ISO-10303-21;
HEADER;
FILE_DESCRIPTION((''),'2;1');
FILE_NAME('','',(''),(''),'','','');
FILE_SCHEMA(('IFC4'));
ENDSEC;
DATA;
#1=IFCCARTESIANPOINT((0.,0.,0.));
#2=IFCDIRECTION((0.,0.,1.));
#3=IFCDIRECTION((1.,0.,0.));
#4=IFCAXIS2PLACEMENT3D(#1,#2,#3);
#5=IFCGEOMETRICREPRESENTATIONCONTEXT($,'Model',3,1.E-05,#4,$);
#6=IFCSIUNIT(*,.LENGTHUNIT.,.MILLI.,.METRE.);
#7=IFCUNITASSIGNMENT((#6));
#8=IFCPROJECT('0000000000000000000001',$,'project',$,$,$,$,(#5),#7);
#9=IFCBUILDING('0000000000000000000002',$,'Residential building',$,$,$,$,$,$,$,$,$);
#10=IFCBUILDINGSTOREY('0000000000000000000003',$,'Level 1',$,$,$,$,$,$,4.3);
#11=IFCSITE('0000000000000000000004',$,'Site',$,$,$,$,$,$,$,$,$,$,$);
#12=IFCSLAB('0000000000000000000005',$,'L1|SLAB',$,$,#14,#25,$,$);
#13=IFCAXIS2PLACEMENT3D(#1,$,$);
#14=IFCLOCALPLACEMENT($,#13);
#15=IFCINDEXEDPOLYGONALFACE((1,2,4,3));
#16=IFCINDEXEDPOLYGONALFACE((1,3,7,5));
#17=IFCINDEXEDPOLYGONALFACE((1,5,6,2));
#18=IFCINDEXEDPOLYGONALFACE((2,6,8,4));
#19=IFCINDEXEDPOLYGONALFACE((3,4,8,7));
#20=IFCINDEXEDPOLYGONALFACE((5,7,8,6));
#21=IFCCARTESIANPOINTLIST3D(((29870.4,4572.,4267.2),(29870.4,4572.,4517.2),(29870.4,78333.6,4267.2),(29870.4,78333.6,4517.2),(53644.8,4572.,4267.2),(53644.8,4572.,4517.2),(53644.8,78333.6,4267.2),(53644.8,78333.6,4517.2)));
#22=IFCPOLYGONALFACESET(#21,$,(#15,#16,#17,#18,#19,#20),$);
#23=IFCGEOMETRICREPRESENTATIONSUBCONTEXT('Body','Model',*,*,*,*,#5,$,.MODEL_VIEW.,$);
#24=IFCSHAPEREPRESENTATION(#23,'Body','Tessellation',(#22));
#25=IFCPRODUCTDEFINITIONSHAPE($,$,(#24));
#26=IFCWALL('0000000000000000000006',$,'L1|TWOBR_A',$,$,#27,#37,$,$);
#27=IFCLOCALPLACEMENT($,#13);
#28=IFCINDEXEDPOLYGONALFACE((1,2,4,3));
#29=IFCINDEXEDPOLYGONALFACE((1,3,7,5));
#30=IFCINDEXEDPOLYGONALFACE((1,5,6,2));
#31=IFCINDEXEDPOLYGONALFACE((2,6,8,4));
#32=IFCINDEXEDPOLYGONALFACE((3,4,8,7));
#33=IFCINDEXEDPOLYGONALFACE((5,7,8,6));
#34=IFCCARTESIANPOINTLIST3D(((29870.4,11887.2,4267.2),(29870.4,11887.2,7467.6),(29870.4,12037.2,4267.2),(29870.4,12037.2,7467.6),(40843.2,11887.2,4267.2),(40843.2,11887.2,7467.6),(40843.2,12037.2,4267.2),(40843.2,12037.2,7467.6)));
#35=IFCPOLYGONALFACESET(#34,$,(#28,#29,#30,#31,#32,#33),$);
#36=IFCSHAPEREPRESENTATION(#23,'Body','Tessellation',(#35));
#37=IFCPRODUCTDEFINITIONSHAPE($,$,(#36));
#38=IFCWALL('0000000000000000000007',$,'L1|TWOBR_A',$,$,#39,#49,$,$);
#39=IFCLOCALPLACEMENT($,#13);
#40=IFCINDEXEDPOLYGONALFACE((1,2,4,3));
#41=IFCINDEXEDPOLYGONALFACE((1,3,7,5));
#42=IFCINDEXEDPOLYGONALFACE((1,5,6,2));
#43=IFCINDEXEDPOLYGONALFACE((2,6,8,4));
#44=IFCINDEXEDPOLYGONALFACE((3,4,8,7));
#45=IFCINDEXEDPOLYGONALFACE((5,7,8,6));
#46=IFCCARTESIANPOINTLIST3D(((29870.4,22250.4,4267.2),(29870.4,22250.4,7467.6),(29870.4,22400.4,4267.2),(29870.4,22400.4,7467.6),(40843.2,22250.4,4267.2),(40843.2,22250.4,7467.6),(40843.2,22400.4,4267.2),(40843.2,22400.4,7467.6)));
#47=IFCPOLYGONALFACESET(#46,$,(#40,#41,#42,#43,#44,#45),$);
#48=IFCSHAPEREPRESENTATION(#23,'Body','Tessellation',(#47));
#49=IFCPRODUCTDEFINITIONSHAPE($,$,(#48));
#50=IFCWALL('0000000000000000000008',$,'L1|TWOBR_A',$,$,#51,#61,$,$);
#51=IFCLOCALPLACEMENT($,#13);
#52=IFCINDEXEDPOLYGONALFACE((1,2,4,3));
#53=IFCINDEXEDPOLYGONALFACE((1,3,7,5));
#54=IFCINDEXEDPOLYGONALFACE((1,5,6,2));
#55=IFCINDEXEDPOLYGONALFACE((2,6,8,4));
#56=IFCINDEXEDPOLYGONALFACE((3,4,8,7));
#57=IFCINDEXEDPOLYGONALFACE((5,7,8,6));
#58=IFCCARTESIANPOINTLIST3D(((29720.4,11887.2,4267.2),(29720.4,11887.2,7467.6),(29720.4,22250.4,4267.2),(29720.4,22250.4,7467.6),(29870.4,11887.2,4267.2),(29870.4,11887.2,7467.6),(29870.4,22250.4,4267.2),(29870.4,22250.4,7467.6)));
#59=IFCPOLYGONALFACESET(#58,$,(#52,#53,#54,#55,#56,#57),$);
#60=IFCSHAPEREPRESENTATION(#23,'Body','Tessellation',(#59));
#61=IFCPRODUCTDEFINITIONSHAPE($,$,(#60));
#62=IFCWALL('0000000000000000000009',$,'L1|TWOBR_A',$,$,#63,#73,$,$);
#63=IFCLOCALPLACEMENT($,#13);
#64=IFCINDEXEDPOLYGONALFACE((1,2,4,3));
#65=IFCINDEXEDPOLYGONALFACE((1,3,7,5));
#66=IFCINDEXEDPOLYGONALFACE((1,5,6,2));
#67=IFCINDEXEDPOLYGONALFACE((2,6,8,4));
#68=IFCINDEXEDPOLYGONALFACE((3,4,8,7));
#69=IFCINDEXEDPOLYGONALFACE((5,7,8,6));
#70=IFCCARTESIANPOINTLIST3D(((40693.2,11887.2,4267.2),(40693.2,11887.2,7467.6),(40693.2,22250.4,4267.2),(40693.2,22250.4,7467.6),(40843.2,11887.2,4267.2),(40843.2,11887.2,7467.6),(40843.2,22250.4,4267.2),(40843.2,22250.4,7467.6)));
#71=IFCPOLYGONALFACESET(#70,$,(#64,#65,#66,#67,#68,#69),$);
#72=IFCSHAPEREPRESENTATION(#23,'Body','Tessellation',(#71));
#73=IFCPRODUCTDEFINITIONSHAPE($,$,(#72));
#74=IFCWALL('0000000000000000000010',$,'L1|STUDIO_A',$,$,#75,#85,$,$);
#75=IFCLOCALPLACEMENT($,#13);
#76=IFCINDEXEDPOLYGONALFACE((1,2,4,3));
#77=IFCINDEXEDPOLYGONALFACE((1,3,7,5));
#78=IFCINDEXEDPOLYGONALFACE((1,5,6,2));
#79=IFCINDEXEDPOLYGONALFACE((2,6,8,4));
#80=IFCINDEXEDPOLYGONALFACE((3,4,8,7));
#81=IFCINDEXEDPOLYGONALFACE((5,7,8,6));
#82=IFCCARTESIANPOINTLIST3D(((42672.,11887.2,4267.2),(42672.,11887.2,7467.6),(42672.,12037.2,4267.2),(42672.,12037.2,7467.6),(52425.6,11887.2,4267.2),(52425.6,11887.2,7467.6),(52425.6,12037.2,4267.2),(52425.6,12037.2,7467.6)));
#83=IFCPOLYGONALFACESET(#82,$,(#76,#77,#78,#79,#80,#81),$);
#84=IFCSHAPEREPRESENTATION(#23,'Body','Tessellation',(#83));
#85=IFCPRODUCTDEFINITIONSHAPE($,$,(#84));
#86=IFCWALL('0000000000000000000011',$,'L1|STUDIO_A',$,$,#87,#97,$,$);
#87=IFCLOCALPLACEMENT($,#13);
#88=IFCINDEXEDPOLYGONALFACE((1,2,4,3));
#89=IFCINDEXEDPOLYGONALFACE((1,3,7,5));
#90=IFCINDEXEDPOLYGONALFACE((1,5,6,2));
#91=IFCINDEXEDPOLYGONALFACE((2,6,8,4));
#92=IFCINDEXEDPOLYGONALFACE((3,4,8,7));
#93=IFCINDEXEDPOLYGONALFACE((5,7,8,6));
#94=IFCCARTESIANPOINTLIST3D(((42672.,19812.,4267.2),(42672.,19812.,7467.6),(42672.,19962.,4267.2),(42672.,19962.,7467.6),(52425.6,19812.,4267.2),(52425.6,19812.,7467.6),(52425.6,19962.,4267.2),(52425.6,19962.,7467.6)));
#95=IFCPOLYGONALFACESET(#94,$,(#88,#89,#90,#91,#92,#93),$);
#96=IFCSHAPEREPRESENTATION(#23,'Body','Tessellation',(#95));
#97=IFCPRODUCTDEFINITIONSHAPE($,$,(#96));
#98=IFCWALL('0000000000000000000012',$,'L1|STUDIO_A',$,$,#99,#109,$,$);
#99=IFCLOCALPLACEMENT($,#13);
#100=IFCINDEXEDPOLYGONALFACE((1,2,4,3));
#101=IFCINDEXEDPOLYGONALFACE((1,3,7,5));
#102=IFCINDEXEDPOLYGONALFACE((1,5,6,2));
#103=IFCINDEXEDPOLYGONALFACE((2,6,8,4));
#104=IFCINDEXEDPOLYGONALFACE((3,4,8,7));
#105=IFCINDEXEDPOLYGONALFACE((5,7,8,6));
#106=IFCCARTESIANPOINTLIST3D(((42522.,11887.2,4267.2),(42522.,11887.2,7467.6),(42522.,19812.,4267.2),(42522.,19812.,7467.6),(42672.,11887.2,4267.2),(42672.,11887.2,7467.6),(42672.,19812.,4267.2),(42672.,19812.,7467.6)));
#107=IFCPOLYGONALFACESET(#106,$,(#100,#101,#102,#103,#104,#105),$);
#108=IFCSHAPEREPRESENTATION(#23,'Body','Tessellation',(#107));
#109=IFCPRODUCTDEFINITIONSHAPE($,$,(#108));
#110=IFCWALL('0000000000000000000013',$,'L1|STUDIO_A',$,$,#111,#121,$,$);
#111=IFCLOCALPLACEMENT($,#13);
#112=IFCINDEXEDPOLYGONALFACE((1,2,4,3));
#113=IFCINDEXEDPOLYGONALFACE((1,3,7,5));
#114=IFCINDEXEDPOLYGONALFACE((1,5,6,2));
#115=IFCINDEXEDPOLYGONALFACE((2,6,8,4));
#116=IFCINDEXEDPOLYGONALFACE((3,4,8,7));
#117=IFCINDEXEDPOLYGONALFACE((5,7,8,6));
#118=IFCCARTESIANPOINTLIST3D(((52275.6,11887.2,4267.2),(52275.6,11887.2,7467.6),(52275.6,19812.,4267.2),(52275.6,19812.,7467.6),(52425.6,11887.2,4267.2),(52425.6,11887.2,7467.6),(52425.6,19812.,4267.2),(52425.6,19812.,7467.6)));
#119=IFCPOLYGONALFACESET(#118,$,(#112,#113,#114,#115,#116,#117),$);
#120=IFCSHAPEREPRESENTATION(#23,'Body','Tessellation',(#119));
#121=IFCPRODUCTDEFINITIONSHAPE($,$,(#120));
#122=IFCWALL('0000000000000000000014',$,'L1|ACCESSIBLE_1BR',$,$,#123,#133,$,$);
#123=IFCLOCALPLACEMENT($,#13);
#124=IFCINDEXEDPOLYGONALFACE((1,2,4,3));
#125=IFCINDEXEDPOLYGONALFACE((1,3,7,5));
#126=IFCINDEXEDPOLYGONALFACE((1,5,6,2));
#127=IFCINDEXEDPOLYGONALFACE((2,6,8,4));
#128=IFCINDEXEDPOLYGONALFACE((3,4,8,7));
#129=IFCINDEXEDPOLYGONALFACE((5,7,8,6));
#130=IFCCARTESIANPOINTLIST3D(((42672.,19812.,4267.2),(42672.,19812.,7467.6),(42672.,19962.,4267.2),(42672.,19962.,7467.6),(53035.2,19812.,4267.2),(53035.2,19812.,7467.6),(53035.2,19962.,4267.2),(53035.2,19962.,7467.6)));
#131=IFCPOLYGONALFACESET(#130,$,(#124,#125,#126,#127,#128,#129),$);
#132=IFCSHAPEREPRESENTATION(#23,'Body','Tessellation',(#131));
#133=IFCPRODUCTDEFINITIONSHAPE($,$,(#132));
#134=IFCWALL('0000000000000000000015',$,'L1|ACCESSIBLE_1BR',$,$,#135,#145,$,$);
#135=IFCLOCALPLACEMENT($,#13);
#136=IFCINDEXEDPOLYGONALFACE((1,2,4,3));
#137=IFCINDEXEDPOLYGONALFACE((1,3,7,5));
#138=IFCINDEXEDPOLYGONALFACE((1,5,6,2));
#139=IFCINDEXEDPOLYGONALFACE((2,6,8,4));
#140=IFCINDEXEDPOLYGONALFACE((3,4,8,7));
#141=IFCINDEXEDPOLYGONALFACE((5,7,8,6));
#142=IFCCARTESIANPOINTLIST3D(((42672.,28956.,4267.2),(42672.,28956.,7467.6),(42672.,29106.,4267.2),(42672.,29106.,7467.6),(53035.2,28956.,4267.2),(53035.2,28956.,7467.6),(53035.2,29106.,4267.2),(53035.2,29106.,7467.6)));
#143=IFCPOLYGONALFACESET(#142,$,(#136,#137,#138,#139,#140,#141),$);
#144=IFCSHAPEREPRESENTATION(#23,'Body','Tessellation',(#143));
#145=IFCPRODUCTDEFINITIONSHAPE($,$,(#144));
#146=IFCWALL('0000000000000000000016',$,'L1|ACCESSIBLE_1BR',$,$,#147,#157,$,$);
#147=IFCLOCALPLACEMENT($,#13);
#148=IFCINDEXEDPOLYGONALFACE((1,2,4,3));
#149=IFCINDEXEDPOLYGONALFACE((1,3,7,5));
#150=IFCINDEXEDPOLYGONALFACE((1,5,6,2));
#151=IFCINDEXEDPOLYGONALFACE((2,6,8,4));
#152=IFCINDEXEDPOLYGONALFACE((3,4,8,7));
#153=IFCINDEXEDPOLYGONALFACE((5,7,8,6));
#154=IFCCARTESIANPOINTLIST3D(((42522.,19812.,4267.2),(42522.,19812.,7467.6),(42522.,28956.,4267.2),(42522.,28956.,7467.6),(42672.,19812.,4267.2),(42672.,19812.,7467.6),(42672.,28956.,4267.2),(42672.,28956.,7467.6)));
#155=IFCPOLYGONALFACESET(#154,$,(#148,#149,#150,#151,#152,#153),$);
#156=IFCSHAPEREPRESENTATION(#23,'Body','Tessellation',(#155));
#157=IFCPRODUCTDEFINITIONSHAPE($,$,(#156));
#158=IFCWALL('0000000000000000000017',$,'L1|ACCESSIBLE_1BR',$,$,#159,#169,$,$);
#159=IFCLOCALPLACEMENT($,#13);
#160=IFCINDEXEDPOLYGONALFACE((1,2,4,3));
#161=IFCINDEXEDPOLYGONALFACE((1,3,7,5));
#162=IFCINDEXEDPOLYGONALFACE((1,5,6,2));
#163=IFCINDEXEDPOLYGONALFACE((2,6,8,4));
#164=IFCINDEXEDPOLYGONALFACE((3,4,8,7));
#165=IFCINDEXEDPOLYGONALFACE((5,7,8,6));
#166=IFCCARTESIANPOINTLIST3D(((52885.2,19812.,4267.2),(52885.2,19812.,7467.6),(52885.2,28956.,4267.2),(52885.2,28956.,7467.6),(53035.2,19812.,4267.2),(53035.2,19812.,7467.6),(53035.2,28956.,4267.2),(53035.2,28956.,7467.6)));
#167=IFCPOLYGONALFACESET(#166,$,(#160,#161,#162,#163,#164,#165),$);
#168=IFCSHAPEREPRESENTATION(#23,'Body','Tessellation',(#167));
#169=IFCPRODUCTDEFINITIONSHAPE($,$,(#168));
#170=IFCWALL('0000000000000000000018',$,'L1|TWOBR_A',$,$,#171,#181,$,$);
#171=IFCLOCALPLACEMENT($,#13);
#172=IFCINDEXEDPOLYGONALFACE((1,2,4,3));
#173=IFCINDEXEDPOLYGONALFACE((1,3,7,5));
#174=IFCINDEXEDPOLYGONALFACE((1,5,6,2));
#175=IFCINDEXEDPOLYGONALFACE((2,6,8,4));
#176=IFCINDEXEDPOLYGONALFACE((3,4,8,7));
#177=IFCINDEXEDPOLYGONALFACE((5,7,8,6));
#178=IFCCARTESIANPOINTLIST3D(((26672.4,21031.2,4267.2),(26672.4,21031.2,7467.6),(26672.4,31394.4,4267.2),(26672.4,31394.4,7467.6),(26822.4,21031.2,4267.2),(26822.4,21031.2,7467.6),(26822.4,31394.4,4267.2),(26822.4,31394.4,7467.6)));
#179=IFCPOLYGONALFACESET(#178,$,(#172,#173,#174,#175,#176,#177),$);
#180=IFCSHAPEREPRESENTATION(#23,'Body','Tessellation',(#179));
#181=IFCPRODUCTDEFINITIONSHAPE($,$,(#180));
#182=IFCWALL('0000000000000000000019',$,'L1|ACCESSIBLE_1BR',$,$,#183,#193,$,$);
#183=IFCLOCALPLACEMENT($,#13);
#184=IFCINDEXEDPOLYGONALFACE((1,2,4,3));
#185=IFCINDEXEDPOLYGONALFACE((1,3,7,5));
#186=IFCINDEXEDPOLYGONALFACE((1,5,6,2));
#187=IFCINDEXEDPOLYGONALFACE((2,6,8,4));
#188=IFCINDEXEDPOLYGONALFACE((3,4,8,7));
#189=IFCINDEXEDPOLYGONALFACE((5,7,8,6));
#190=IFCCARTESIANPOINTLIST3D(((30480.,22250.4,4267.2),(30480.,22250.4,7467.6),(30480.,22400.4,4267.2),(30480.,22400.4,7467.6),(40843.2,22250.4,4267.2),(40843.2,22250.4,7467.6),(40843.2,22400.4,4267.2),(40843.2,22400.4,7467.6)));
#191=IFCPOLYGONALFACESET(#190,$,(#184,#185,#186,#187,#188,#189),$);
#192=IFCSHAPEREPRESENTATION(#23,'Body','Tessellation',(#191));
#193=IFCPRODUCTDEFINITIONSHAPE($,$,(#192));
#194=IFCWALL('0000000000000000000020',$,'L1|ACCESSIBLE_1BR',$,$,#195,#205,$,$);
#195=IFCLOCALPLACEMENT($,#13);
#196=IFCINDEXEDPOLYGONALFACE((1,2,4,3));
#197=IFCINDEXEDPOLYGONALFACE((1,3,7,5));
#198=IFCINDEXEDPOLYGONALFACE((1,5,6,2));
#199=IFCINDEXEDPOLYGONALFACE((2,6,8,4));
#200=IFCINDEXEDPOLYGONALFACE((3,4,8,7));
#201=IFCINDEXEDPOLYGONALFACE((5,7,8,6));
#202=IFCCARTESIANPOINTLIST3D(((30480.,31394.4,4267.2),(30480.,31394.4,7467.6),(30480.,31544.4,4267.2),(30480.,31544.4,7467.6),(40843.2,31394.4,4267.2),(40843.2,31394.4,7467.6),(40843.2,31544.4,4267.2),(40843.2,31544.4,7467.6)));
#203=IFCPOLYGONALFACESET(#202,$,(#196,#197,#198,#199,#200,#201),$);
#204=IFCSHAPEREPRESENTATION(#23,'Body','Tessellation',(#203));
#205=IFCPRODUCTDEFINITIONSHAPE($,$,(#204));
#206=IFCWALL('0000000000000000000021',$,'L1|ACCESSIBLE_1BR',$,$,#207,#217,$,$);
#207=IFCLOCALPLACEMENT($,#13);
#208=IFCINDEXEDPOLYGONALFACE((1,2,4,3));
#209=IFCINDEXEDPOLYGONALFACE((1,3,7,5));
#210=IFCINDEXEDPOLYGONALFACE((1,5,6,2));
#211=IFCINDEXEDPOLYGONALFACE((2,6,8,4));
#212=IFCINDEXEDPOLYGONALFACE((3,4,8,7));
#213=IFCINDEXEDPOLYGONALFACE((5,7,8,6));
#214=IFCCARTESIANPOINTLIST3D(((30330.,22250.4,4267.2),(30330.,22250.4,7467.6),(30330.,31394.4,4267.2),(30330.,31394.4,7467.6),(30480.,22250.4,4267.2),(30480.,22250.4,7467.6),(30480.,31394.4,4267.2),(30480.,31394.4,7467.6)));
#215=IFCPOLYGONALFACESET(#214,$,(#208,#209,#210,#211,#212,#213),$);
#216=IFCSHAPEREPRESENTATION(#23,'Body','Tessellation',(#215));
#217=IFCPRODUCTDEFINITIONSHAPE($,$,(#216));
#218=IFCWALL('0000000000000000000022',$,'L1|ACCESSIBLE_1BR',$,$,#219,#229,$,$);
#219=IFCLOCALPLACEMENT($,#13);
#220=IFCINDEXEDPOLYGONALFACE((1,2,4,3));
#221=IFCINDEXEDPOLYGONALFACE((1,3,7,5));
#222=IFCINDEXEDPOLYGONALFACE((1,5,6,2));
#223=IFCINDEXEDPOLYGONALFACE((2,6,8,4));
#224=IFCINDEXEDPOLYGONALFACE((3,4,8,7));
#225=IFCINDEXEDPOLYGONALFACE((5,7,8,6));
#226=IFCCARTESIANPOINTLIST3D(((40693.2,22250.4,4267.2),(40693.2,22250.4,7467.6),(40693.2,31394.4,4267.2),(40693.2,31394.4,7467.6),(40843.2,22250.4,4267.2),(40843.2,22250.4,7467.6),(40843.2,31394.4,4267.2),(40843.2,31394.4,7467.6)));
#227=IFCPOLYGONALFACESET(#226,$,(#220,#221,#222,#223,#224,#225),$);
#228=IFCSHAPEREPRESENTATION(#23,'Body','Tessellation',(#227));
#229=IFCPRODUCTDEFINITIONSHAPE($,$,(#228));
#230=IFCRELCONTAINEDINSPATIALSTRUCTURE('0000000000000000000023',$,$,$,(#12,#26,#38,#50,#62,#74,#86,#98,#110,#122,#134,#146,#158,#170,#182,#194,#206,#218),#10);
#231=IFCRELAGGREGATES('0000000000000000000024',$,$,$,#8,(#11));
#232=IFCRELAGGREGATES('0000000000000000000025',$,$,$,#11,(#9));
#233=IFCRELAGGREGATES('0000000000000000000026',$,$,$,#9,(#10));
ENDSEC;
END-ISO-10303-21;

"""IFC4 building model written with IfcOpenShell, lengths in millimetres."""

from ifc_helpers import new_model, si_unit, frame, origin_with_axes, place, context, subcontext, project, spatial, indexed_curve, outline, extrude, element, save


model = new_model("IFC4")

# Units and contexts
model_context = context("Model", 3, precision=1e-05, world=origin_with_axes())
body_context = subcontext(model_context, "Body", "Model", "MODEL_VIEW")
ifc_project = project(units=[si_unit("LENGTHUNIT", "METRE", prefix="MILLI")], contexts=[model_context])

# Site, building, storey
site = spatial("IfcSite", under=ifc_project, Name="Site")
building = spatial("IfcBuilding", under=site, Name="Residential building")
storey = spatial("IfcBuildingStorey", under=building, Name="Level 1", Elevation=4.3)

# Slab
slab_placement = place(None, frame((29870.4, 4572.0, 4267.2), z_axis=(0.0, 0.0, 1.0), x_axis=(1.0, 0.0, 0.0)))
element("IfcSlab", 1, at=slab_placement, inside=storey, Name="L1|SLAB", context=body_context, shape_type="SweptSolid", body=[
    extrude(outline(indexed_curve([(0.0, 0.0), (23774.4, 0.0), (23774.4, 73761.6), (0.0, 73761.6), (0.0, 0.0)])), None, (0.0, 0.0, 1.0), 250.0),
])

# Walls
for number, where, z_axis, x_axis, name in (
    (2, (29870.4, 11887.2, 4267.2), (0.0, 0.0, 1.0), (1.0, 0.0, 0.0), "L1|TWOBR_A"),
    (3, (29870.4, 22250.4, 4267.2), (0.0, 0.0, 1.0), (1.0, 0.0, 0.0), "L1|TWOBR_A"),
):
    element("IfcWall", number, at=place(None, frame(where, z_axis=z_axis, x_axis=x_axis)), inside=storey, Name=name, context=body_context, shape_type="SweptSolid", body=[
        extrude(outline(indexed_curve([(0.0, 0.0), (0.0, 150.0), (10972.8, 150.0), (10972.8, 0.0), (0.0, 0.0)], self_intersect=False)), origin_with_axes(), (0.0, 0.0, 1.0), 3200.4),
    ])
for number, where, z_axis, x_axis, name in (
    (4, (29870.4, 11887.2, 4267.2), (0.0, 0.0, 1.0), (0.0, 1.0, 0.0), "L1|TWOBR_A"),
    (5, (40843.2, 11887.2, 4267.2), (0.0, 0.0, 1.0), (0.0, 1.0, 0.0), "L1|TWOBR_A"),
):
    element("IfcWall", number, at=place(None, frame(where, z_axis=z_axis, x_axis=x_axis)), inside=storey, Name=name, context=body_context, shape_type="SweptSolid", body=[
        extrude(outline(indexed_curve([(0.0, 0.0), (0.0, 150.0), (10363.2, 150.0), (10363.2, 0.0), (0.0, 0.0)], self_intersect=False)), origin_with_axes(), (0.0, 0.0, 1.0), 3200.4),
    ])
for number, where, z_axis, x_axis, name in (
    (6, (42672.0, 11887.2, 4267.2), (0.0, 0.0, 1.0), (1.0, 0.0, 0.0), "L1|STUDIO_A"),
    (7, (42672.0, 19812.0, 4267.2), (0.0, 0.0, 1.0), (1.0, 0.0, 0.0), "L1|STUDIO_A"),
):
    element("IfcWall", number, at=place(None, frame(where, z_axis=z_axis, x_axis=x_axis)), inside=storey, Name=name, context=body_context, shape_type="SweptSolid", body=[
        extrude(outline(indexed_curve([(0.0, 0.0), (0.0, 150.0), (9753.6, 150.0), (9753.6, 0.0), (0.0, 0.0)], self_intersect=False)), origin_with_axes(), (0.0, 0.0, 1.0), 3200.4),
    ])
for number, where, z_axis, x_axis, name in (
    (8, (42672.0, 11887.2, 4267.2), (0.0, 0.0, 1.0), (0.0, 1.0, 0.0), "L1|STUDIO_A"),
    (9, (52425.6, 11887.2, 4267.2), (0.0, 0.0, 1.0), (0.0, 1.0, 0.0), "L1|STUDIO_A"),
):
    element("IfcWall", number, at=place(None, frame(where, z_axis=z_axis, x_axis=x_axis)), inside=storey, Name=name, context=body_context, shape_type="SweptSolid", body=[
        extrude(outline(indexed_curve([(0.0, 0.0), (0.0, 150.0), (7924.8, 150.0), (7924.8, 0.0), (0.0, 0.0)], self_intersect=False)), origin_with_axes(), (0.0, 0.0, 1.0), 3200.4),
    ])
for number, where, z_axis, x_axis, name in (
    (10, (42672.0, 19812.0, 4267.2), (0.0, 0.0, 1.0), (1.0, 0.0, 0.0), "L1|ACCESSIBLE_1BR"),
    (11, (42672.0, 28956.0, 4267.2), (0.0, 0.0, 1.0), (1.0, 0.0, 0.0), "L1|ACCESSIBLE_1BR"),
):
    element("IfcWall", number, at=place(None, frame(where, z_axis=z_axis, x_axis=x_axis)), inside=storey, Name=name, context=body_context, shape_type="SweptSolid", body=[
        extrude(outline(indexed_curve([(0.0, 0.0), (0.0, 150.0), (10363.2, 150.0), (10363.2, 0.0), (0.0, 0.0)], self_intersect=False)), origin_with_axes(), (0.0, 0.0, 1.0), 3200.4),
    ])
for number, where, z_axis, x_axis, name in (
    (12, (42672.0, 19812.0, 4267.2), (0.0, 0.0, 1.0), (0.0, 1.0, 0.0), "L1|ACCESSIBLE_1BR"),
    (13, (53035.2, 19812.0, 4267.2), (0.0, 0.0, 1.0), (0.0, 1.0, 0.0), "L1|ACCESSIBLE_1BR"),
):
    element("IfcWall", number, at=place(None, frame(where, z_axis=z_axis, x_axis=x_axis)), inside=storey, Name=name, context=body_context, shape_type="SweptSolid", body=[
        extrude(outline(indexed_curve([(0.0, 0.0), (0.0, 150.0), (9144.0, 150.0), (9144.0, 0.0), (0.0, 0.0)], self_intersect=False)), origin_with_axes(), (0.0, 0.0, 1.0), 3200.4),
    ])
for number, where, z_axis, x_axis, name in (
    (14, (26822.4, 21031.2, 4267.2), (0.0, 0.0, 1.0), (0.0, 1.0, 0.0), "L1|TWOBR_A"),
    (15, (30480.0, 22250.4, 4267.2), (0.0, 0.0, 1.0), (1.0, 0.0, 0.0), "L1|ACCESSIBLE_1BR"),
    (16, (30480.0, 31394.4, 4267.2), (0.0, 0.0, 1.0), (1.0, 0.0, 0.0), "L1|ACCESSIBLE_1BR"),
):
    element("IfcWall", number, at=place(None, frame(where, z_axis=z_axis, x_axis=x_axis)), inside=storey, Name=name, context=body_context, shape_type="SweptSolid", body=[
        extrude(outline(indexed_curve([(0.0, 0.0), (0.0, 150.0), (10363.2, 150.0), (10363.2, 0.0), (0.0, 0.0)], self_intersect=False)), origin_with_axes(), (0.0, 0.0, 1.0), 3200.4),
    ])
for number, where, z_axis, x_axis, name in (
    (17, (30480.0, 22250.4, 4267.2), (0.0, 0.0, 1.0), (0.0, 1.0, 0.0), "L1|ACCESSIBLE_1BR"),
    (18, (40843.2, 22250.4, 4267.2), (0.0, 0.0, 1.0), (0.0, 1.0, 0.0), "L1|ACCESSIBLE_1BR"),
):
    element("IfcWall", number, at=place(None, frame(where, z_axis=z_axis, x_axis=x_axis)), inside=storey, Name=name, context=body_context, shape_type="SweptSolid", body=[
        extrude(outline(indexed_curve([(0.0, 0.0), (0.0, 150.0), (9144.0, 150.0), (9144.0, 0.0), (0.0, 0.0)], self_intersect=False)), origin_with_axes(), (0.0, 0.0, 1.0), 3200.4),
    ])

save(model, "model.ifc")
